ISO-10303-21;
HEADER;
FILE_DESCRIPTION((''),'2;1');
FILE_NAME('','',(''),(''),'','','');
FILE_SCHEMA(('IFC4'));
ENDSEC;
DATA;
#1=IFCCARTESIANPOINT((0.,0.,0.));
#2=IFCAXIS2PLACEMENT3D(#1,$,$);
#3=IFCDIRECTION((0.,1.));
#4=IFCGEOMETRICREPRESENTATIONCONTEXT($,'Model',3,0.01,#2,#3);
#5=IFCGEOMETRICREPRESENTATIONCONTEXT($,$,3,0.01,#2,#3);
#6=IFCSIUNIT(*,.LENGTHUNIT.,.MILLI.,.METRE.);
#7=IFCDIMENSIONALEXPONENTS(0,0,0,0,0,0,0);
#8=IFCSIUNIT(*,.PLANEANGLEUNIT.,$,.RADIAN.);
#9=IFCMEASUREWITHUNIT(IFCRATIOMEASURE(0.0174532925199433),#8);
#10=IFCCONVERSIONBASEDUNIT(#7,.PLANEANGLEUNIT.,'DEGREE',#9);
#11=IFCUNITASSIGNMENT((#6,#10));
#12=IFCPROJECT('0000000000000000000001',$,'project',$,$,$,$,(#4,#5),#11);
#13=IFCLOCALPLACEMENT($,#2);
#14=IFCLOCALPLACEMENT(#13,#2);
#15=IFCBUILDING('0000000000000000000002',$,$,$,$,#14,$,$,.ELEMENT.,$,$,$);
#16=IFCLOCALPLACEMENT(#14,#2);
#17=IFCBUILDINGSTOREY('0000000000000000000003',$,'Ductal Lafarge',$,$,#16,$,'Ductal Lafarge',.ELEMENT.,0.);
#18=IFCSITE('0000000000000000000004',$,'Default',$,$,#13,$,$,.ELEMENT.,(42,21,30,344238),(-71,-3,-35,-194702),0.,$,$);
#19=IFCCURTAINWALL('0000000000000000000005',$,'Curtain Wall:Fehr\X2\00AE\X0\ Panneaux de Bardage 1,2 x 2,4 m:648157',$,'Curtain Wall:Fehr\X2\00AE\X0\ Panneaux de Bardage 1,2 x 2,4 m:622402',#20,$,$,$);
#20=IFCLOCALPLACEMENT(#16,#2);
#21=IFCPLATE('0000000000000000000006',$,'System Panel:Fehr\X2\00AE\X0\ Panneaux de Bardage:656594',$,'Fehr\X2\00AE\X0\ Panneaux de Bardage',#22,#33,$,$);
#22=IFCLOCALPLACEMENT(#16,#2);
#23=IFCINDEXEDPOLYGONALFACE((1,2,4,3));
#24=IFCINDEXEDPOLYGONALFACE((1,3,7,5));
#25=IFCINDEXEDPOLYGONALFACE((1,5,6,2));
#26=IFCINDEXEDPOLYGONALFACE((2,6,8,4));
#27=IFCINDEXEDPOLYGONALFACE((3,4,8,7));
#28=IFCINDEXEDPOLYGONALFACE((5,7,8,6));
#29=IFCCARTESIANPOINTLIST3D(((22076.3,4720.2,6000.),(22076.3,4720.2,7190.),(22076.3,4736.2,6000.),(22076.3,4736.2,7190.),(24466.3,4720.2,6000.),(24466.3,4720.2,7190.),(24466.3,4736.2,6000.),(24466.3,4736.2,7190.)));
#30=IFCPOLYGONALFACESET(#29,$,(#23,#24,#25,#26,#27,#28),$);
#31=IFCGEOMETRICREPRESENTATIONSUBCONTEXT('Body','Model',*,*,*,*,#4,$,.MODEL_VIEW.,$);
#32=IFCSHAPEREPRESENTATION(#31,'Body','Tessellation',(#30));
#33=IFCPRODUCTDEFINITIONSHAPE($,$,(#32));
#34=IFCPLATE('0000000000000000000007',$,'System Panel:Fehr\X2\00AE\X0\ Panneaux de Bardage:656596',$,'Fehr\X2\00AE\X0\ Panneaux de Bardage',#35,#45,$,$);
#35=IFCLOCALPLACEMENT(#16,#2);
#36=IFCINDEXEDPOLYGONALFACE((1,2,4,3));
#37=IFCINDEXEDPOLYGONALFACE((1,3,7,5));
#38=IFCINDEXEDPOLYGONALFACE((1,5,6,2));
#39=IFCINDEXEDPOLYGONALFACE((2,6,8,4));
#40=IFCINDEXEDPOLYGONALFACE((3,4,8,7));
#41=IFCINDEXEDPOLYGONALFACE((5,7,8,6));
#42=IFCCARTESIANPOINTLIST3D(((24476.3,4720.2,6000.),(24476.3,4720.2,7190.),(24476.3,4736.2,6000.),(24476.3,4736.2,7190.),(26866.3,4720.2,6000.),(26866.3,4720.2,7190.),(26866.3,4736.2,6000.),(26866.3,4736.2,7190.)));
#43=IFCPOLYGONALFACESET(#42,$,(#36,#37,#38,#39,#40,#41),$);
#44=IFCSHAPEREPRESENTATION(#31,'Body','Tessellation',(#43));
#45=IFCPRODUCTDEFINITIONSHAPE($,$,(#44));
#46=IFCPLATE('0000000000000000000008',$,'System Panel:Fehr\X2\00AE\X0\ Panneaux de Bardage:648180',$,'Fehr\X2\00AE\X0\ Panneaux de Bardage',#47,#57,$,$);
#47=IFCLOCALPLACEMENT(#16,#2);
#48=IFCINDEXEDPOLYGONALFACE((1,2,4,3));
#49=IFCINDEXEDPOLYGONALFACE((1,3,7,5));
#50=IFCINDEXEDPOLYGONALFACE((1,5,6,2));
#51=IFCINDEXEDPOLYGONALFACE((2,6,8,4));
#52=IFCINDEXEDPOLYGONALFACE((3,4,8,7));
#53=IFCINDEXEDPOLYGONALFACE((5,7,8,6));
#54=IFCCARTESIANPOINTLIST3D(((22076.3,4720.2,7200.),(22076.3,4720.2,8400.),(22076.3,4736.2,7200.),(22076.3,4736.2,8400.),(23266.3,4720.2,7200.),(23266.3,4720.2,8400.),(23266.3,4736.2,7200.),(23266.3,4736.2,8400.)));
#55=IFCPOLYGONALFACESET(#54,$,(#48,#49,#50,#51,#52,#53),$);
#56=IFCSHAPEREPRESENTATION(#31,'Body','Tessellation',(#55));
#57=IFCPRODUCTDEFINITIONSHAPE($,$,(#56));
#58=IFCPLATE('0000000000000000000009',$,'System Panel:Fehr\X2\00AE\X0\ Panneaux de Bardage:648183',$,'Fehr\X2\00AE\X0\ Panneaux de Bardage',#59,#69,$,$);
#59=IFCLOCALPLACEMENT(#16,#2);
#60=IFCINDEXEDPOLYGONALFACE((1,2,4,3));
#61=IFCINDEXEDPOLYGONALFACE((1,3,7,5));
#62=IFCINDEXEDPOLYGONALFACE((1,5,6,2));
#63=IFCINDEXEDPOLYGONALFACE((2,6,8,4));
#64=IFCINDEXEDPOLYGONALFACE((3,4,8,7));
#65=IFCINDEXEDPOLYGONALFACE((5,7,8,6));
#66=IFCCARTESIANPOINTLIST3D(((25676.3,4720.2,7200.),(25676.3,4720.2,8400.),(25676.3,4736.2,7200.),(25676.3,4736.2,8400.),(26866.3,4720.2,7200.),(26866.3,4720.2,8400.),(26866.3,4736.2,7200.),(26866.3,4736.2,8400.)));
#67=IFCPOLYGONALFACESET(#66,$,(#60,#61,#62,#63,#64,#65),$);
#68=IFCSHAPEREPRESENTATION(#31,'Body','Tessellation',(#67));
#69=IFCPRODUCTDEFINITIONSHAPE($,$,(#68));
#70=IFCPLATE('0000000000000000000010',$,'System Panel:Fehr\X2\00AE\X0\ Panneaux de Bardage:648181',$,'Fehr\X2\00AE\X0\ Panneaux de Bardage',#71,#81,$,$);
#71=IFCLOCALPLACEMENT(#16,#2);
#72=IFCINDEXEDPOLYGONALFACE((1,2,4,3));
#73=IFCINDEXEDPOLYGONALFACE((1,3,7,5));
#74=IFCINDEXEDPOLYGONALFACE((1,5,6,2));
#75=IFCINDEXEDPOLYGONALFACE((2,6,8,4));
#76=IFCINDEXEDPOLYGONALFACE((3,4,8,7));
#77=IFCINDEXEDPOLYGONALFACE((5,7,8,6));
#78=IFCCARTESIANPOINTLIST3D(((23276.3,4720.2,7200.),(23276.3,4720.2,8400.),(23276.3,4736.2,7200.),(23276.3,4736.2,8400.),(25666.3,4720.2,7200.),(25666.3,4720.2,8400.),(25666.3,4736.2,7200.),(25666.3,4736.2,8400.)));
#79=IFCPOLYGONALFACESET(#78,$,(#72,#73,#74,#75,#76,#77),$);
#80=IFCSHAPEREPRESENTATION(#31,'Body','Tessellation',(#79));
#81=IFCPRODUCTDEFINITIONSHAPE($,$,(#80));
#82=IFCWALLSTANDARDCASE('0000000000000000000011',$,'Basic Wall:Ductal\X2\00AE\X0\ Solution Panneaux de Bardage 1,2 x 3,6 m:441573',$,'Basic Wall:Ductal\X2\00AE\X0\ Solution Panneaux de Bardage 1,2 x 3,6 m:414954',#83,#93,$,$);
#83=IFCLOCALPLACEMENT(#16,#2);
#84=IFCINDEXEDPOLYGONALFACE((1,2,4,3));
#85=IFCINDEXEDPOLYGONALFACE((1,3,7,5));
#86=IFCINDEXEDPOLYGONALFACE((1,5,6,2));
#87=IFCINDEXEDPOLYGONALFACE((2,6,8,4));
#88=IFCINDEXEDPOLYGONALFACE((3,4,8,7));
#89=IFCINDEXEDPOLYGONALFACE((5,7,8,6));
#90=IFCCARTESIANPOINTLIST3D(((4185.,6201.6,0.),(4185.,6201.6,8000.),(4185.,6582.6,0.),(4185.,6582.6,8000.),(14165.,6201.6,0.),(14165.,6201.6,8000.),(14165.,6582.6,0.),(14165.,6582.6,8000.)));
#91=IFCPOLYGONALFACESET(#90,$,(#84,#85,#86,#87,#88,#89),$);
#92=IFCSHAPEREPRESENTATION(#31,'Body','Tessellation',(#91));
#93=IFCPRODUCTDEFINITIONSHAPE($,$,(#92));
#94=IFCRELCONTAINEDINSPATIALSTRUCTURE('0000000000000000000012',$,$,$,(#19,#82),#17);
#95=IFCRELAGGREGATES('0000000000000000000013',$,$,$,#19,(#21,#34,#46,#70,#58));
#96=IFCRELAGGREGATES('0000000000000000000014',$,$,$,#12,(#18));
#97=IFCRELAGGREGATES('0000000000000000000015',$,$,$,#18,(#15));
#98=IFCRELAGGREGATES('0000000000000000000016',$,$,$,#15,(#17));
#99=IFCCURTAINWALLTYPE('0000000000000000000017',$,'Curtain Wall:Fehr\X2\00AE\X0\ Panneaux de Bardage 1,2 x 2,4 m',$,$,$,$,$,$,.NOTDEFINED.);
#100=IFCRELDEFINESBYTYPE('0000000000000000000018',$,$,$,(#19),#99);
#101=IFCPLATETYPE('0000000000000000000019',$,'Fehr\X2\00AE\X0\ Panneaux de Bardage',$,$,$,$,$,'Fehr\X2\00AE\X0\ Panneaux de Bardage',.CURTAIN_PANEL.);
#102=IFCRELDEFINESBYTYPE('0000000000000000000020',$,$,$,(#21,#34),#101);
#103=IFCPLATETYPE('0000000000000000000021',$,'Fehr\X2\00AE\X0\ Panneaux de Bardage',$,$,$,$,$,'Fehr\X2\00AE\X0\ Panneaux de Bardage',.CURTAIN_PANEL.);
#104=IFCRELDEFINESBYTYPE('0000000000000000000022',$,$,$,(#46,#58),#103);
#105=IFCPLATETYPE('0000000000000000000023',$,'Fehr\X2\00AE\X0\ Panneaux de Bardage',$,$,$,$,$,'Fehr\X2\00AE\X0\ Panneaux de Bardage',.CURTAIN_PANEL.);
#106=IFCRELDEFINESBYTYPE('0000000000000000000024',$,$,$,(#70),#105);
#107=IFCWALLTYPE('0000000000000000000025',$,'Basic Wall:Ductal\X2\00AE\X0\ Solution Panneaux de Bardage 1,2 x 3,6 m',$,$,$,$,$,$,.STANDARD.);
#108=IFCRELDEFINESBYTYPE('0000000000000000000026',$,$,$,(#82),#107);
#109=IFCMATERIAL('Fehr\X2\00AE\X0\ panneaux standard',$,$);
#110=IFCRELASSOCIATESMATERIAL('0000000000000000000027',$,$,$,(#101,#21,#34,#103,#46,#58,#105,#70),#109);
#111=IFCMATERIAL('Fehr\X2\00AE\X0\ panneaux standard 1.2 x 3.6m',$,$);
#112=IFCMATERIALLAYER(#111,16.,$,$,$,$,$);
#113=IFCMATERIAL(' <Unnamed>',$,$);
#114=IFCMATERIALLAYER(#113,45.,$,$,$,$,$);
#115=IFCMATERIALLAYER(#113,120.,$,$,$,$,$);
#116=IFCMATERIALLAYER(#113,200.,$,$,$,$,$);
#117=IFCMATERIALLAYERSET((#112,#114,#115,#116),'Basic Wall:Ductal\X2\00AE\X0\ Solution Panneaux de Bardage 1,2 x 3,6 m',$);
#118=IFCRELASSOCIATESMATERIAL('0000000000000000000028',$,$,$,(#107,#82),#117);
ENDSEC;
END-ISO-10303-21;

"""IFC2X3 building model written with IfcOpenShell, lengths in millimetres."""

from ifc_helpers import new_model, entity, si_unit, converted_unit, direction, frame, frame_2d, origin, origin_2d_with_axis, place, context, subcontext, project, spatial, rectangle, extrude, source, transform, mapped, material, layer, layer_set, layer_usage, type_object, type_shapes, element, aggregate, save


model = new_model("IFC2X3")

# Units and contexts
model_context = context("Model", 3, precision=0.01, world=origin(), true_north=direction((0.0, 1.0)))
context_of_model = context(None, 3, precision=0.01, world=origin(), true_north=direction((0.0, 1.0)))
body_context = subcontext(model_context, "Body", "Model", "MODEL_VIEW")
ifc_project = project(units=[si_unit("LENGTHUNIT", "METRE", prefix="MILLI"), converted_unit("PLANEANGLEUNIT", "DEGREE", entity("IfcRatioMeasure", 0.0174532925199433), si_unit("PLANEANGLEUNIT", "RADIAN"), dimensions=[0, 0, 0, 0, 0, 0, 0])], contexts=[model_context, context_of_model])

# Site, building, storey
site_placement = place(None, origin())
site = spatial("IfcSite", under=ifc_project, at=site_placement, Name="Default", CompositionType="ELEMENT", RefLatitude=(42, 21, 30, 344238), RefLongitude=(-71, -3, -35, -194702), RefElevation=0.0)
building_placement = place(site_placement, origin())
building = spatial("IfcBuilding", under=site, at=building_placement, CompositionType="ELEMENT")
storey_placement = place(building_placement, origin())
storey = spatial("IfcBuildingStorey", under=building, at=storey_placement, Name="Ductal Lafarge", LongName="Ductal Lafarge", CompositionType="ELEMENT", Elevation=0.0)

# Curtain wall, plates
curtain_wall_type = type_object("IfcCurtainWallType", Name="Curtain Wall:Fehr® Panneaux de Bardage 1,2 x 2,4 m", PredefinedType="NOTDEFINED")
curtain_wall_placement = place(storey_placement, origin())
curtain_wall = element("IfcCurtainWall", 1, at=curtain_wall_placement, inside=storey, type_object=curtain_wall_type, Name="Curtain Wall:Fehr® Panneaux de Bardage 1,2 x 2,4 m:648157", ObjectType="Curtain Wall:Fehr® Panneaux de Bardage 1,2 x 2,4 m:622402")
ifc_material_1 = material(Name="Fehr® panneaux standard")
plate_type_1 = type_object("IfcPlateType", Name="Fehr® Panneaux de Bardage", ElementType="Fehr® Panneaux de Bardage", PredefinedType="CURTAIN_PANEL", material=ifc_material_1)
shared_shape_1 = source(origin(), body_context, "Body", "SweptSolid", [
    extrude(rectangle(XDim=1190.0, YDim=2390.0, at=origin_2d_with_axis()), frame((0.0, -8.0, 595.0), z_axis=(0.0, 1.0, 0.0), x_axis=(0.0, 0.0, 1.0)), (0.0, 0.0, 1.0), 16.0),
])
type_shapes(plate_type_1, [shared_shape_1])
plate_1_placement = place(curtain_wall_placement, frame((23271.3, 4728.2, 6000.0)))
plate_1 = element("IfcPlate", 2, at=plate_1_placement, type_object=plate_type_1, material=ifc_material_1, Name="System Panel:Fehr® Panneaux de Bardage:656594", ObjectType="Fehr® Panneaux de Bardage", context=body_context, shape_type="MappedRepresentation", body=[
    mapped(shared_shape_1, transform((0.0, 0.0, 0.0), scale=1.0)),
])
plate_2_placement = place(curtain_wall_placement, frame((25671.3, 4728.2, 6000.0)))
plate_2 = element("IfcPlate", 3, at=plate_2_placement, type_object=plate_type_1, material=ifc_material_1, Name="System Panel:Fehr® Panneaux de Bardage:656596", ObjectType="Fehr® Panneaux de Bardage", context=body_context, shape_type="MappedRepresentation", body=[
    mapped(shared_shape_1, transform((0.0, 0.0, 0.0), scale=1.0)),
])
plate_type_2 = type_object("IfcPlateType", Name="Fehr® Panneaux de Bardage", ElementType="Fehr® Panneaux de Bardage", PredefinedType="CURTAIN_PANEL", material=ifc_material_1)
shared_shape_2 = source(origin(), body_context, "Body", "SweptSolid", [
    extrude(rectangle(XDim=16.0, YDim=1190.0, at=origin_2d_with_axis()), frame((0.0, 0.0, 0.0), z_axis=(0.0, 0.0, 1.0), x_axis=(0.0, 1.0, 0.0)), (0.0, 0.0, 1.0), 1200.0),
])
type_shapes(plate_type_2, [shared_shape_2])
plate_3_placement = place(curtain_wall_placement, frame((22671.3, 4728.2, 7200.0)))
plate_3 = element("IfcPlate", 4, at=plate_3_placement, type_object=plate_type_2, material=ifc_material_1, Name="System Panel:Fehr® Panneaux de Bardage:648180", ObjectType="Fehr® Panneaux de Bardage", context=body_context, shape_type="MappedRepresentation", body=[
    mapped(shared_shape_2, transform((0.0, 0.0, 0.0), scale=1.0)),
])
plate_4_placement = place(curtain_wall_placement, frame((26271.3, 4728.2, 7200.0)))
plate_4 = element("IfcPlate", 5, at=plate_4_placement, type_object=plate_type_2, material=ifc_material_1, Name="System Panel:Fehr® Panneaux de Bardage:648183", ObjectType="Fehr® Panneaux de Bardage", context=body_context, shape_type="MappedRepresentation", body=[
    mapped(shared_shape_2, transform((0.0, 0.0, 0.0), scale=1.0)),
])
plate_type_3 = type_object("IfcPlateType", Name="Fehr® Panneaux de Bardage", ElementType="Fehr® Panneaux de Bardage", PredefinedType="CURTAIN_PANEL", material=ifc_material_1)
shared_shape_3 = source(origin(), body_context, "Body", "SweptSolid", [
    extrude(rectangle(XDim=1200.0, YDim=2390.0, at=origin_2d_with_axis()), frame((0.0, -8.0, 600.0), z_axis=(0.0, 1.0, 0.0), x_axis=(0.0, 0.0, 1.0)), (0.0, 0.0, 1.0), 16.0),
])
type_shapes(plate_type_3, [shared_shape_3])
plate_5_placement = place(curtain_wall_placement, frame((24471.3, 4728.2, 7200.0)))
plate_5 = element("IfcPlate", 6, at=plate_5_placement, type_object=plate_type_3, material=ifc_material_1, Name="System Panel:Fehr® Panneaux de Bardage:648181", ObjectType="Fehr® Panneaux de Bardage", context=body_context, shape_type="MappedRepresentation", body=[
    mapped(shared_shape_3, transform((0.0, 0.0, 0.0), scale=1.0)),
])
aggregate(curtain_wall, [plate_1, plate_2, plate_3, plate_5, plate_4])

# Wall
ifc_material_2 = material(Name="Fehr® panneaux standard 1.2 x 3.6m")
ifc_layer_1 = layer(ifc_material_2, 16.0)
ifc_material_3 = material(Name=" <Unnamed>")
ifc_layer_2 = layer(ifc_material_3, 45.0)
ifc_layer_3 = layer(ifc_material_3, 120.0)
ifc_layer_4 = layer(ifc_material_3, 200.0)
ifc_layer_set = layer_set([ifc_layer_1, ifc_layer_2, ifc_layer_3, ifc_layer_4], Name="Basic Wall:Ductal® Solution Panneaux de Bardage 1,2 x 3,6 m")
ifc_layer_usage = layer_usage(ifc_layer_set, "AXIS2", "NEGATIVE", 190.5)
wall_type = type_object("IfcWallType", Name="Basic Wall:Ductal® Solution Panneaux de Bardage 1,2 x 3,6 m", PredefinedType="STANDARD", material=ifc_layer_set)
wall_placement = place(storey_placement, frame((14165.0, 6392.1, 0.0), z_axis=(0.0, 0.0, 1.0), x_axis=(-1.0, 0.0, 0.0)))
element("IfcWallStandardCase", 7, at=wall_placement, inside=storey, type_object=wall_type, material=ifc_layer_usage, Name="Basic Wall:Ductal® Solution Panneaux de Bardage 1,2 x 3,6 m:441573", ObjectType="Basic Wall:Ductal® Solution Panneaux de Bardage 1,2 x 3,6 m:414954", context=body_context, shape_type="SweptSolid", body=[
    extrude(rectangle(XDim=9980.0, YDim=381.0, at=frame_2d((4990.0, 0.0), x_axis=(-1.0, 0.0))), origin(), (0.0, 0.0, 1.0), 8000.0),
])

save(model, "model.ifc")
